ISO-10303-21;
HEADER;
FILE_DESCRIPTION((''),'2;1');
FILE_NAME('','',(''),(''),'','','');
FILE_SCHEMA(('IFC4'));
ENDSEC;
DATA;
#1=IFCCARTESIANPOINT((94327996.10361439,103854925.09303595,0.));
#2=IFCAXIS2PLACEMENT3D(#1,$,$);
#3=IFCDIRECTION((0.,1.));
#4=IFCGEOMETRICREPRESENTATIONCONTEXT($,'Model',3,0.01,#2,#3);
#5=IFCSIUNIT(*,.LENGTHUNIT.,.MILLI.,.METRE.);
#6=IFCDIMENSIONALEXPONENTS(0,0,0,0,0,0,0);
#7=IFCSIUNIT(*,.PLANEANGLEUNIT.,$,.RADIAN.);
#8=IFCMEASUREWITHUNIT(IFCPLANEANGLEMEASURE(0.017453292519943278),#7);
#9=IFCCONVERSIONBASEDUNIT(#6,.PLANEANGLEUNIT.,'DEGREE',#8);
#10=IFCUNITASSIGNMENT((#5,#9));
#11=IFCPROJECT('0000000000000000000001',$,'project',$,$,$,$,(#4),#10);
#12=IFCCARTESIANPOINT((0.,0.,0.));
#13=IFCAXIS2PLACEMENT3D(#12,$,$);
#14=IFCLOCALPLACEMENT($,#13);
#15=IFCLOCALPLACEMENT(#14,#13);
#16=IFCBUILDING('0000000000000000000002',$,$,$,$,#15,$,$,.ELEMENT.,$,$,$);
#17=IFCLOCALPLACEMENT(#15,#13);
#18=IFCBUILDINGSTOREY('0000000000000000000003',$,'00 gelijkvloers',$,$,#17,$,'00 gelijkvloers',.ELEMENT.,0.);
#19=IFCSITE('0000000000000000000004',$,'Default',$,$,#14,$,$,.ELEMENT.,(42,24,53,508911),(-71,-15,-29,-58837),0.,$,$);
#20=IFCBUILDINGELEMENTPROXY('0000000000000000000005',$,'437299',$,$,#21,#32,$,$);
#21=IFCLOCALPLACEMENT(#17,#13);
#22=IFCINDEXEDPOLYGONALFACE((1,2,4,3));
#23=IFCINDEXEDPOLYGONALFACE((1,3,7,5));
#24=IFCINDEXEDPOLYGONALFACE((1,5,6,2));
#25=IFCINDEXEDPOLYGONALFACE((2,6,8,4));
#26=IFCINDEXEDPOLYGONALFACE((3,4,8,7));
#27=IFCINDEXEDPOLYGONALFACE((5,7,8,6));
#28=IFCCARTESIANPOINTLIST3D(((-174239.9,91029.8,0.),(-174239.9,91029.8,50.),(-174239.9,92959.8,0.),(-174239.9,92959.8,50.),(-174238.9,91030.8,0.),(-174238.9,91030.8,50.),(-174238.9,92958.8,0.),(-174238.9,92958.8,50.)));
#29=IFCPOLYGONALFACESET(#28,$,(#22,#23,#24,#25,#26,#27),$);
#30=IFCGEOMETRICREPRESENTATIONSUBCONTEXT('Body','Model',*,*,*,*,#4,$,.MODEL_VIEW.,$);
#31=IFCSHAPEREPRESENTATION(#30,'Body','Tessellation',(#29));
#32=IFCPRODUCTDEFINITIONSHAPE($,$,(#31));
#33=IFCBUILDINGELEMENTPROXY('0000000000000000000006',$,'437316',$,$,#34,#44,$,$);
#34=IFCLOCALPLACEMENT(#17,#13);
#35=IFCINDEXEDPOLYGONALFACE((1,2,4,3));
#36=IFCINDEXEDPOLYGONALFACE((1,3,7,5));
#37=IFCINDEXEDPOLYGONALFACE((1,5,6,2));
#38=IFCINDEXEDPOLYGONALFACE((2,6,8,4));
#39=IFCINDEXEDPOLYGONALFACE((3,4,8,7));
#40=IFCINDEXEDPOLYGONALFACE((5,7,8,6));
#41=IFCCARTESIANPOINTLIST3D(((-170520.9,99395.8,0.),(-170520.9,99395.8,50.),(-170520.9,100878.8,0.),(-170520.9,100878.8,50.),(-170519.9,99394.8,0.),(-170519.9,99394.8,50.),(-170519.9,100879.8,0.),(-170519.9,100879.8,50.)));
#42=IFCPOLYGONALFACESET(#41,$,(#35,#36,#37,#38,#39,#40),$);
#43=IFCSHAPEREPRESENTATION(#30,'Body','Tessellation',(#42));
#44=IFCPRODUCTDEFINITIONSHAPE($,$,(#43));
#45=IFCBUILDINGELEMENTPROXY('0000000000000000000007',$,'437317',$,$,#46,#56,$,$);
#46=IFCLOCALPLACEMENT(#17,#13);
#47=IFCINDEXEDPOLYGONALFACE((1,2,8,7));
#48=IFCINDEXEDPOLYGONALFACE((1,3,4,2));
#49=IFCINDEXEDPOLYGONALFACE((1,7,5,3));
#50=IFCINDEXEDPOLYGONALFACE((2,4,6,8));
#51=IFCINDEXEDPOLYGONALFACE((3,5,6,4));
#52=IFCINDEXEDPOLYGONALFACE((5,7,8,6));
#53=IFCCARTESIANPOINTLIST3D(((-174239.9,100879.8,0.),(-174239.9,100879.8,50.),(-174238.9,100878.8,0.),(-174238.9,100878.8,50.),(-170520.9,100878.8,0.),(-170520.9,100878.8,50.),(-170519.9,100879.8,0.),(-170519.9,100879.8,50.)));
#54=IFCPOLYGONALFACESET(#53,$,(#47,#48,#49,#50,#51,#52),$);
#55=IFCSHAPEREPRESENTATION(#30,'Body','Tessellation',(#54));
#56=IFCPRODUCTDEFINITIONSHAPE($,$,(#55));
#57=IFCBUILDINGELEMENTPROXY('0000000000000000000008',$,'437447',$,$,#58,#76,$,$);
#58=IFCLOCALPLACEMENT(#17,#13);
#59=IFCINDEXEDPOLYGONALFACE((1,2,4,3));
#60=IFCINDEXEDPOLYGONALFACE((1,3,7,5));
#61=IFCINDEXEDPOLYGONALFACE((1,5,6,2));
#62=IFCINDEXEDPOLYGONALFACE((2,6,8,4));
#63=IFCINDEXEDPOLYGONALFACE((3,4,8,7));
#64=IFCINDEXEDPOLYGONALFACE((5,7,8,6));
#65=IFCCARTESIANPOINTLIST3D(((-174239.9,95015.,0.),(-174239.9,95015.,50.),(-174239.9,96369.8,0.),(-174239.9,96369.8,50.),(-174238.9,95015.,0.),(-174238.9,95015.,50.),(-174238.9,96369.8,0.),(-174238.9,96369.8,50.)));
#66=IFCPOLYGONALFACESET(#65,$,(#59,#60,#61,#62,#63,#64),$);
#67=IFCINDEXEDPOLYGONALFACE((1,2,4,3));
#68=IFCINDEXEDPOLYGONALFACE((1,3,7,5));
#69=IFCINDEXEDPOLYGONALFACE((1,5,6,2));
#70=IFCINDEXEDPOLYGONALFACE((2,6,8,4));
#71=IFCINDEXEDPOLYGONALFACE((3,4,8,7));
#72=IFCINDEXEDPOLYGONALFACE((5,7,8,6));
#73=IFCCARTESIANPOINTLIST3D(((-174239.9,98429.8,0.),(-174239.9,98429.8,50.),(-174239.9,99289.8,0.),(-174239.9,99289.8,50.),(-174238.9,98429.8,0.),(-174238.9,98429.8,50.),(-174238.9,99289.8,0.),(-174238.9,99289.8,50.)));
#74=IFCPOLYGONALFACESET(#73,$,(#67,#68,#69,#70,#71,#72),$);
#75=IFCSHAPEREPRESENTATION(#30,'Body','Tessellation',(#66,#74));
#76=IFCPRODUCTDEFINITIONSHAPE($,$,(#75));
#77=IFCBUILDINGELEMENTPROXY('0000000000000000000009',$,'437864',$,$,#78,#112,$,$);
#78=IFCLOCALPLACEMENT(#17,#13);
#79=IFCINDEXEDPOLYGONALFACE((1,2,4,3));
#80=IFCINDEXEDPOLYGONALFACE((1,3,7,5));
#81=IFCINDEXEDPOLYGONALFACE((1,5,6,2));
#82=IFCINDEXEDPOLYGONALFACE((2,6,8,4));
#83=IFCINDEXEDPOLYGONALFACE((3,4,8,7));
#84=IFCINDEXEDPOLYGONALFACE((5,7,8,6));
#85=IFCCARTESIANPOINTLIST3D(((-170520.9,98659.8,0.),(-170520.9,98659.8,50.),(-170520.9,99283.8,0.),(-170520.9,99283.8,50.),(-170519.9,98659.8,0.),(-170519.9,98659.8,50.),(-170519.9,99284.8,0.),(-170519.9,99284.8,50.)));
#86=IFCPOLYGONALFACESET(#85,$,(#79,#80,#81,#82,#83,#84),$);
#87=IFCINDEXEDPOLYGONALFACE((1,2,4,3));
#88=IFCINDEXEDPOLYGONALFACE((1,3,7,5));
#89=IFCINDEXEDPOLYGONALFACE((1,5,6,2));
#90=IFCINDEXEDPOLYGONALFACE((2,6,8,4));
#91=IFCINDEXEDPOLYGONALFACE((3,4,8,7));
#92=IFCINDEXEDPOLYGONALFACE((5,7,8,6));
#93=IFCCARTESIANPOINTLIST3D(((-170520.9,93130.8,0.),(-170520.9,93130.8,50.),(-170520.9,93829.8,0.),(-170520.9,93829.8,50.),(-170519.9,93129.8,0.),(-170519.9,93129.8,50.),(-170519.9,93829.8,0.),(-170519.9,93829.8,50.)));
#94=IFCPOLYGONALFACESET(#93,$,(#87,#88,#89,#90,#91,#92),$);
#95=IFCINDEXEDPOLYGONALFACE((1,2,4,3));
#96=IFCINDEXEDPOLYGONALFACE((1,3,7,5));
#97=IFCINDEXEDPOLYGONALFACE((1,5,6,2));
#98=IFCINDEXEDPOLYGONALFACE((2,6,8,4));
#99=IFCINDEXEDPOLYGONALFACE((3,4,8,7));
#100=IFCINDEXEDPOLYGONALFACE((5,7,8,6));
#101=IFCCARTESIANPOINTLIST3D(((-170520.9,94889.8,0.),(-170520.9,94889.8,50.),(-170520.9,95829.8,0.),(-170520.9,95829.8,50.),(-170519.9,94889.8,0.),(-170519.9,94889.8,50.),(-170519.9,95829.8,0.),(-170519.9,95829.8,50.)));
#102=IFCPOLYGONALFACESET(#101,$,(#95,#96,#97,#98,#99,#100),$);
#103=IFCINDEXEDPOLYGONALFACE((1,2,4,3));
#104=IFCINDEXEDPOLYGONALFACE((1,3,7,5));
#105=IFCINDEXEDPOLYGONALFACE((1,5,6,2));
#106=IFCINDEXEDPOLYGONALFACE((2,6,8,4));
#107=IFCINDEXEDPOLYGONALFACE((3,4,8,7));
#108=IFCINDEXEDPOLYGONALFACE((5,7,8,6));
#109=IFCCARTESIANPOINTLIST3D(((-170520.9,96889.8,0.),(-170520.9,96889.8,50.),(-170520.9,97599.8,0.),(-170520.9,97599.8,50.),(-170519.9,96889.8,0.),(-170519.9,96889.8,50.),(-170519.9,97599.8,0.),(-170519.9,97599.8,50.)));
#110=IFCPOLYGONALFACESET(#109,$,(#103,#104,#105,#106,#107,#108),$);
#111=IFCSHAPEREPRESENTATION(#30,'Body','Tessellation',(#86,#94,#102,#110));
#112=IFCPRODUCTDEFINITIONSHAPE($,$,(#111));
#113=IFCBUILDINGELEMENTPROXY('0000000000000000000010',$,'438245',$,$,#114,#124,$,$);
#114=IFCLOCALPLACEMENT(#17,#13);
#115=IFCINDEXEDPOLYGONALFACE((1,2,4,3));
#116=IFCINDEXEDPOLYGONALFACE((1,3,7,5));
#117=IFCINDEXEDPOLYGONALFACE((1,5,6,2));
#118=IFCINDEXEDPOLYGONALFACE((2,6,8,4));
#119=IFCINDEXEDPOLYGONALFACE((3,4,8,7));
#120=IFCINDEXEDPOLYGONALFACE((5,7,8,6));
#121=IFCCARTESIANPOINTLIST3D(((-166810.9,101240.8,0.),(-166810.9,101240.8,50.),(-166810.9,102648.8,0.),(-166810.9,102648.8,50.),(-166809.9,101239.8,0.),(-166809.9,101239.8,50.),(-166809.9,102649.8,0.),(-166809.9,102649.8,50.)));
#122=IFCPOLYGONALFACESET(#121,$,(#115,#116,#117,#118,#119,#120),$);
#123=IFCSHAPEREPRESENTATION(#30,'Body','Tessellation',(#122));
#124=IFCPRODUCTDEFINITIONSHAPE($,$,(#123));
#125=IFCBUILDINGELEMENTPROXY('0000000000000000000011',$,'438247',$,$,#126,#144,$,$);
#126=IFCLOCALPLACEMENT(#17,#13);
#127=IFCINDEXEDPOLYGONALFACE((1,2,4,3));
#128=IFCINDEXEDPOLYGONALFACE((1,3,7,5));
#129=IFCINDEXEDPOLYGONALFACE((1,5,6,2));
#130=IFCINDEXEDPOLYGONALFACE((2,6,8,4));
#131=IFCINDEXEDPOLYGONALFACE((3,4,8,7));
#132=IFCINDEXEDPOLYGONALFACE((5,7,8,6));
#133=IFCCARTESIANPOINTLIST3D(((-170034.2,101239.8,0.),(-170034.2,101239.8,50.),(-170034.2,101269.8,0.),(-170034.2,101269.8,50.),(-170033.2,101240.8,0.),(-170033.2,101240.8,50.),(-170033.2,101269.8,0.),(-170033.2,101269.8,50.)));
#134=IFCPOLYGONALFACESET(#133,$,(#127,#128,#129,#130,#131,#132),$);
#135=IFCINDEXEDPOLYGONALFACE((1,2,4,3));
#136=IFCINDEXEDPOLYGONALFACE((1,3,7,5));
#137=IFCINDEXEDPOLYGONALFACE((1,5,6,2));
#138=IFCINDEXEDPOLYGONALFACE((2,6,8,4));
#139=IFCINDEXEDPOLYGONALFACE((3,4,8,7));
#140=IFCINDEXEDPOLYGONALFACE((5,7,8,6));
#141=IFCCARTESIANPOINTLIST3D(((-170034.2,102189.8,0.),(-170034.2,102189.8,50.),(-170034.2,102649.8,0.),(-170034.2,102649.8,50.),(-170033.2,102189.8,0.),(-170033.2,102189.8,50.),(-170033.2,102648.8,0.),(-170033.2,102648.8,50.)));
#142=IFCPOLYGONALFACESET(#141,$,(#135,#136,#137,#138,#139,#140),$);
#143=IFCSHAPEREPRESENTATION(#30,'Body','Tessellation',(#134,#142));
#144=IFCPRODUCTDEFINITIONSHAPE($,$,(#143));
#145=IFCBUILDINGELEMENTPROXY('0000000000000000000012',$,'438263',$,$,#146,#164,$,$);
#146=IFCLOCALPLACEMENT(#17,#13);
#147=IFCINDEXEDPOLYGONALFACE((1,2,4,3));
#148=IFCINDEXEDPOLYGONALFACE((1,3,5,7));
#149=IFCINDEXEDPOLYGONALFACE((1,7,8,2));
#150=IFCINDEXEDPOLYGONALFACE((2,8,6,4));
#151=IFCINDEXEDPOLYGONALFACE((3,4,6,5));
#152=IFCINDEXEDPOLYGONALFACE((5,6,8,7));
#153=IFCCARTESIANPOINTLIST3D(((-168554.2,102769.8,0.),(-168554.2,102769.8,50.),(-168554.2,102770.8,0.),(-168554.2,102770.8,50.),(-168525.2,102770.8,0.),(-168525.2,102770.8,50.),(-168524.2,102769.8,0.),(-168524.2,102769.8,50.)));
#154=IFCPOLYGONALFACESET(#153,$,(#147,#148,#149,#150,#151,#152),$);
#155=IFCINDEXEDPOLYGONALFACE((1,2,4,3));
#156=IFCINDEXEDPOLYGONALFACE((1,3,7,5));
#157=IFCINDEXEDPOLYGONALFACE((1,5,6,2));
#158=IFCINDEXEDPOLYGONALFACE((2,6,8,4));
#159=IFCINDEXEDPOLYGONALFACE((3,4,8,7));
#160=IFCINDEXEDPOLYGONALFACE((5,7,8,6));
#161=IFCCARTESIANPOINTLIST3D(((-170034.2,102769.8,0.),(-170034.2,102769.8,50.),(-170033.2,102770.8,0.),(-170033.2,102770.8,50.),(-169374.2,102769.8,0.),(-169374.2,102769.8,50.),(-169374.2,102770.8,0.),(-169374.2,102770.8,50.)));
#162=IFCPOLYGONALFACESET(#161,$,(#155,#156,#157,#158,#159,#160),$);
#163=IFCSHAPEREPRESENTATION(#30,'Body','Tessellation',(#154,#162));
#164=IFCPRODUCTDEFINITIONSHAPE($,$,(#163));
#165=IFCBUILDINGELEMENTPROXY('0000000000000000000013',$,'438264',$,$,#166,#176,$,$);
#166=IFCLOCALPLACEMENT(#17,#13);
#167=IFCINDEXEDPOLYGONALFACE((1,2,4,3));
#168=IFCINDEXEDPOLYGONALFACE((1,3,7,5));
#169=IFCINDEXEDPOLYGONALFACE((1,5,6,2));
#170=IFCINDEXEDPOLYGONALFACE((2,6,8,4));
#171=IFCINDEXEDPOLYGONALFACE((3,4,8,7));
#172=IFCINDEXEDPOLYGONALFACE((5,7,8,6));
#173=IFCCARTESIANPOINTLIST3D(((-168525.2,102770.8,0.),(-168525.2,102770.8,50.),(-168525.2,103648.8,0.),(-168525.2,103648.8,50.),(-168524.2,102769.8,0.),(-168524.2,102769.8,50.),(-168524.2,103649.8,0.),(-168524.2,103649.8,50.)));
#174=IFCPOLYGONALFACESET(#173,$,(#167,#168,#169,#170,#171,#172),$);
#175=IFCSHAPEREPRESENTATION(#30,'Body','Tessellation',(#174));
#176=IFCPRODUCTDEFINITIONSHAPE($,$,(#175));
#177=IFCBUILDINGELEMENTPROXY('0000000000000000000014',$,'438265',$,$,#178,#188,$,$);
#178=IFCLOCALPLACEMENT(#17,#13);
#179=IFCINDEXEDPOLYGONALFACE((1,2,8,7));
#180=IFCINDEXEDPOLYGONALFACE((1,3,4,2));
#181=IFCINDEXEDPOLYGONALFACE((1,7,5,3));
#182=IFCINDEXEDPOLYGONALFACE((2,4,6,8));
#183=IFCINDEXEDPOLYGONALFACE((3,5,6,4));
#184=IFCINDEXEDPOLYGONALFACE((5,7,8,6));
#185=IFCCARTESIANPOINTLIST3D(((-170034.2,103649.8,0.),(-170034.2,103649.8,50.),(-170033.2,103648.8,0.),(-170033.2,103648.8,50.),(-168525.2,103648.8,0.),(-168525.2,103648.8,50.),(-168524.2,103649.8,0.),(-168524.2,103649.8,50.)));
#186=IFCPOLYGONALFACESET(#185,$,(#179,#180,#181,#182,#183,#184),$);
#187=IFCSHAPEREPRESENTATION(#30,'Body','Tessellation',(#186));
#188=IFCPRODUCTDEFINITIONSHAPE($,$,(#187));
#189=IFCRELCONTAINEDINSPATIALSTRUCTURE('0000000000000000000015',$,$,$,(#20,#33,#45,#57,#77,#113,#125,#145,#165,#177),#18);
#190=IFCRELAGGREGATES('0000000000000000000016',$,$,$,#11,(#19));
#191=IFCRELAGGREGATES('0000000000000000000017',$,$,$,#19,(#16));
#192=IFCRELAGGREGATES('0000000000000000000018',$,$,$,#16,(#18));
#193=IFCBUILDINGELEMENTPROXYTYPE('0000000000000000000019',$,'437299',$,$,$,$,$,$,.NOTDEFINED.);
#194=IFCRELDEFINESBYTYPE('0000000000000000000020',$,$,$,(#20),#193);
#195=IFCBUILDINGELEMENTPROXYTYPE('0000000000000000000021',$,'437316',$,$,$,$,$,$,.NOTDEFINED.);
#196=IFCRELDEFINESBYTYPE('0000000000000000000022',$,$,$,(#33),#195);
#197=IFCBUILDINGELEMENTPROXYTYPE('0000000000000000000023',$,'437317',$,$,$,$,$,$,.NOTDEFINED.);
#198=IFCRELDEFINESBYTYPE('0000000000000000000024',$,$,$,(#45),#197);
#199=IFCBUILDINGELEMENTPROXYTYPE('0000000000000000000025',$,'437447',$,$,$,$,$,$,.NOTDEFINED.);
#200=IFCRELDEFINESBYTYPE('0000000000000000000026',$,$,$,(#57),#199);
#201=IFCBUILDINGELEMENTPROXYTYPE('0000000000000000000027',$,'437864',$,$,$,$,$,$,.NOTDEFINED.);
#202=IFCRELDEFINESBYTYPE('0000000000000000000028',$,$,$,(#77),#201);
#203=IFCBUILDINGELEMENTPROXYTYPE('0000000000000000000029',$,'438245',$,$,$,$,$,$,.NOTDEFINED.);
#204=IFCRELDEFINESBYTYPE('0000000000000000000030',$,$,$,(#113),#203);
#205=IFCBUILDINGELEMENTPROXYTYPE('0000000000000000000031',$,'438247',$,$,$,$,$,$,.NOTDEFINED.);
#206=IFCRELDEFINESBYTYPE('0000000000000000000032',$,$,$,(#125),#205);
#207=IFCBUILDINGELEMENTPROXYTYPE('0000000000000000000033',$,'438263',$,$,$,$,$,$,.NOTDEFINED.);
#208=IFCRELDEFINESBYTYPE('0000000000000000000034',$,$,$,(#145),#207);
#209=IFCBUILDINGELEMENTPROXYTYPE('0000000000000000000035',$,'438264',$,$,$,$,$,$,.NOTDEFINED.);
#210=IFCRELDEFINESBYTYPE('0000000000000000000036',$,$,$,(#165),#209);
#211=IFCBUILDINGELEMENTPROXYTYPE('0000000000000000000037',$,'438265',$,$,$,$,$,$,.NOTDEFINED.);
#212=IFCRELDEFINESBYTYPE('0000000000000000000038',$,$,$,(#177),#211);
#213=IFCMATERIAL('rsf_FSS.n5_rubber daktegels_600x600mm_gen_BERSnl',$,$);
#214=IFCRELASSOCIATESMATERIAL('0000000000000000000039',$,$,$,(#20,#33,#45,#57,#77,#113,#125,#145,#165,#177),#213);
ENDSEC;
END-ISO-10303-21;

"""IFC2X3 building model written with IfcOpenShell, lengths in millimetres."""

from ifc_helpers import new_model, entity, si_unit, converted_unit, direction, frame, frame_2d, origin, place, context, subcontext, project, spatial, polyline, rectangle, outline, extrude, material, type_object, element, save


model = new_model("IFC2X3")

# Units and contexts
model_context = context("Model", 3, precision=0.01, world=frame((94327996.10361439, 103854925.09303595, 0.0)), true_north=direction((0.0, 1.0)))
body_context = subcontext(model_context, "Body", "Model", "MODEL_VIEW")
ifc_project = project(units=[si_unit("LENGTHUNIT", "METRE", prefix="MILLI"), converted_unit("PLANEANGLEUNIT", "DEGREE", entity("IfcPlaneAngleMeasure", 0.017453292519943278), si_unit("PLANEANGLEUNIT", "RADIAN"), dimensions=[0, 0, 0, 0, 0, 0, 0])], contexts=[model_context])

# Site, building, storey
site_placement = place(None, origin())
site = spatial("IfcSite", under=ifc_project, at=site_placement, Name="Default", CompositionType="ELEMENT", RefLatitude=(42, 24, 53, 508911), RefLongitude=(-71, -15, -29, -58837), RefElevation=0.0)
building_placement = place(site_placement, origin())
building = spatial("IfcBuilding", under=site, at=building_placement, CompositionType="ELEMENT")
storey_placement = place(building_placement, origin())
storey = spatial("IfcBuildingStorey", under=building, at=storey_placement, Name="00 gelijkvloers", LongName="00 gelijkvloers", CompositionType="ELEMENT", Elevation=0.0)

# Building element proxies
ifc_material = material(Name="rsf_FSS.n5_rubber daktegels_600x600mm_gen_BERSnl")
building_element_proxy_type_1 = type_object("IfcBuildingElementProxyType", Name="437299", PredefinedType="NOTDEFINED")
proxy_1_placement = place(storey_placement, origin())
element("IfcBuildingElementProxy", 1, at=proxy_1_placement, inside=storey, type_object=building_element_proxy_type_1, material=ifc_material, Name="437299", context=body_context, shape_type="SweptSolid", body=[
    extrude(outline(polyline([(-964.0, -0.5), (964.0, -0.5), (965.0, 0.5), (-965.0, 0.5), (-964.0, -0.5)])), frame((-174239.4, 91994.8, 0.0), z_axis=(0.0, 0.0, 1.0), x_axis=(0.0, 1.0, 0.0)), (0.0, 0.0, 1.0), 50.0),
])
building_element_proxy_type_2 = type_object("IfcBuildingElementProxyType", Name="437316", PredefinedType="NOTDEFINED")
proxy_2_placement = place(storey_placement, origin())
element("IfcBuildingElementProxy", 2, at=proxy_2_placement, inside=storey, type_object=building_element_proxy_type_2, material=ifc_material, Name="437316", context=body_context, shape_type="SweptSolid", body=[
    extrude(outline(polyline([(-741.5, -0.5), (741.5, -0.5), (742.5, 0.5), (-742.5, 0.5), (-741.5, -0.5)])), frame((-170520.4, 100137.3, 0.0), z_axis=(0.0, 0.0, 1.0), x_axis=(0.0, -1.0, 0.0)), (0.0, 0.0, 1.0), 50.0),
])
building_element_proxy_type_3 = type_object("IfcBuildingElementProxyType", Name="437317", PredefinedType="NOTDEFINED")
proxy_3_placement = place(storey_placement, origin())
element("IfcBuildingElementProxy", 3, at=proxy_3_placement, inside=storey, type_object=building_element_proxy_type_3, material=ifc_material, Name="437317", context=body_context, shape_type="SweptSolid", body=[
    extrude(outline(polyline([(-1859.0, -0.5), (1859.0, -0.5), (1860.0, 0.5), (-1860.0, 0.5), (-1859.0, -0.5)])), frame((-172379.9, 100879.3, 0.0)), (0.0, 0.0, 1.0), 50.0),
])
building_element_proxy_type_4 = type_object("IfcBuildingElementProxyType", Name="437447", PredefinedType="NOTDEFINED")
proxy_4_placement = place(storey_placement, origin())
element("IfcBuildingElementProxy", 4, at=proxy_4_placement, inside=storey, type_object=building_element_proxy_type_4, material=ifc_material, Name="437447", context=body_context, shape_type="SweptSolid", body=[
    extrude(rectangle(XDim=1354.8, YDim=1.0, at=frame_2d((133.5, -0.1), x_axis=(1.0, 0.0))), frame((-174239.5, 95558.9, 0.0), z_axis=(0.0, 0.0, 1.0), x_axis=(0.0, 1.0, 0.0)), (0.0, 0.0, 1.0), 50.0),
    extrude(rectangle(XDim=860.0, YDim=1.0, at=frame_2d((0.0, 0.0), x_axis=(1.0, 0.0))), frame((-174239.4, 98859.8, 0.0), z_axis=(0.0, 0.0, 1.0), x_axis=(0.0, 1.0, 0.0)), (0.0, 0.0, 1.0), 50.0),
])
building_element_proxy_type_5 = type_object("IfcBuildingElementProxyType", Name="437864", PredefinedType="NOTDEFINED")
proxy_5_placement = place(storey_placement, origin())
element("IfcBuildingElementProxy", 5, at=proxy_5_placement, inside=storey, type_object=building_element_proxy_type_5, material=ifc_material, Name="437864", context=body_context, shape_type="SweptSolid", body=[
    extrude(outline(polyline([(-311.8, -0.5), (312.3, -0.5), (312.3, 0.5), (-312.8, 0.5), (-311.8, -0.5)])), frame((-170520.4, 98972.0, 0.0), z_axis=(0.0, 0.0, 1.0), x_axis=(0.0, -1.0, 0.0)), (0.0, 0.0, 1.0), 50.0),
    extrude(outline(polyline([(-349.7, -0.5), (349.2, -0.5), (350.2, 0.5), (-349.7, 0.5), (-349.7, -0.5)])), frame((-170520.4, 93480.0, 0.0), z_axis=(0.0, 0.0, 1.0), x_axis=(0.0, -1.0, 0.0)), (0.0, 0.0, 1.0), 50.0),
    extrude(rectangle(XDim=940.0, YDim=1.0, at=frame_2d((0.0, 0.0), x_axis=(1.0, 0.0))), frame((-170520.4, 95359.8, 0.0), z_axis=(0.0, 0.0, 1.0), x_axis=(0.0, -1.0, 0.0)), (0.0, 0.0, 1.0), 50.0),
    extrude(rectangle(XDim=710.0, YDim=1.0, at=frame_2d((0.0, 0.0), x_axis=(1.0, 0.0))), frame((-170520.4, 97244.8, 0.0), z_axis=(0.0, 0.0, 1.0), x_axis=(0.0, -1.0, 0.0)), (0.0, 0.0, 1.0), 50.0),
])
building_element_proxy_type_6 = type_object("IfcBuildingElementProxyType", Name="438245", PredefinedType="NOTDEFINED")
proxy_6_placement = place(storey_placement, origin())
element("IfcBuildingElementProxy", 6, at=proxy_6_placement, inside=storey, type_object=building_element_proxy_type_6, material=ifc_material, Name="438245", context=body_context, shape_type="SweptSolid", body=[
    extrude(outline(polyline([(-704.0, -0.5), (704.0, -0.5), (705.0, 0.5), (-705.0, 0.5), (-704.0, -0.5)])), frame((-166810.4, 101944.8, 0.0), z_axis=(0.0, 0.0, 1.0), x_axis=(0.0, -1.0, 0.0)), (0.0, 0.0, 1.0), 50.0),
])
building_element_proxy_type_7 = type_object("IfcBuildingElementProxyType", Name="438247", PredefinedType="NOTDEFINED")
proxy_7_placement = place(storey_placement, origin())
element("IfcBuildingElementProxy", 7, at=proxy_7_placement, inside=storey, type_object=building_element_proxy_type_7, material=ifc_material, Name="438247", context=body_context, shape_type="SweptSolid", body=[
    extrude(outline(polyline([(-14.2, -0.5), (14.7, -0.5), (14.7, 0.5), (-15.2, 0.5), (-14.2, -0.5)])), frame((-170033.7, 101255.0, 0.0), z_axis=(0.0, 0.0, 1.0), x_axis=(0.0, 1.0, 0.0)), (0.0, 0.0, 1.0), 50.0),
    extrude(outline(polyline([(-229.8, -0.5), (229.3, -0.5), (230.3, 0.5), (-229.8, 0.5), (-229.8, -0.5)])), frame((-170033.7, 102419.5, 0.0), z_axis=(0.0, 0.0, 1.0), x_axis=(0.0, 1.0, 0.0)), (0.0, 0.0, 1.0), 50.0),
])
building_element_proxy_type_8 = type_object("IfcBuildingElementProxyType", Name="438263", PredefinedType="NOTDEFINED")
proxy_8_placement = place(storey_placement, origin())
element("IfcBuildingElementProxy", 8, at=proxy_8_placement, inside=storey, type_object=building_element_proxy_type_8, material=ifc_material, Name="438263", context=body_context, shape_type="SweptSolid", body=[
    extrude(outline(polyline([(-14.2, -0.5), (14.7, -0.5), (14.7, 0.5), (-15.2, 0.5), (-14.2, -0.5)])), frame((-168539.4, 102770.3, 0.0), z_axis=(0.0, 0.0, 1.0), x_axis=(-1.0, 0.0, 0.0)), (0.0, 0.0, 1.0), 50.0),
    extrude(outline(polyline([(-329.8, -0.5), (329.3, -0.5), (330.3, 0.5), (-329.8, 0.5), (-329.8, -0.5)])), frame((-169703.9, 102770.3, 0.0), z_axis=(0.0, 0.0, 1.0), x_axis=(-1.0, 0.0, 0.0)), (0.0, 0.0, 1.0), 50.0),
])
building_element_proxy_type_9 = type_object("IfcBuildingElementProxyType", Name="438264", PredefinedType="NOTDEFINED")
proxy_9_placement = place(storey_placement, origin())
element("IfcBuildingElementProxy", 9, at=proxy_9_placement, inside=storey, type_object=building_element_proxy_type_9, material=ifc_material, Name="438264", context=body_context, shape_type="SweptSolid", body=[
    extrude(outline(polyline([(-439.0, -0.5), (439.0, -0.5), (440.0, 0.5), (-440.0, 0.5), (-439.0, -0.5)])), frame((-168524.7, 103209.8, 0.0), z_axis=(0.0, 0.0, 1.0), x_axis=(0.0, -1.0, 0.0)), (0.0, 0.0, 1.0), 50.0),
])
building_element_proxy_type_10 = type_object("IfcBuildingElementProxyType", Name="438265", PredefinedType="NOTDEFINED")
proxy_10_placement = place(storey_placement, origin())
element("IfcBuildingElementProxy", 10, at=proxy_10_placement, inside=storey, type_object=building_element_proxy_type_10, material=ifc_material, Name="438265", context=body_context, shape_type="SweptSolid", body=[
    extrude(outline(polyline([(-754.0, -0.5), (754.0, -0.5), (755.0, 0.5), (-755.0, 0.5), (-754.0, -0.5)])), frame((-169279.2, 103649.3, 0.0)), (0.0, 0.0, 1.0), 50.0),
])

save(model, "model.ifc")
